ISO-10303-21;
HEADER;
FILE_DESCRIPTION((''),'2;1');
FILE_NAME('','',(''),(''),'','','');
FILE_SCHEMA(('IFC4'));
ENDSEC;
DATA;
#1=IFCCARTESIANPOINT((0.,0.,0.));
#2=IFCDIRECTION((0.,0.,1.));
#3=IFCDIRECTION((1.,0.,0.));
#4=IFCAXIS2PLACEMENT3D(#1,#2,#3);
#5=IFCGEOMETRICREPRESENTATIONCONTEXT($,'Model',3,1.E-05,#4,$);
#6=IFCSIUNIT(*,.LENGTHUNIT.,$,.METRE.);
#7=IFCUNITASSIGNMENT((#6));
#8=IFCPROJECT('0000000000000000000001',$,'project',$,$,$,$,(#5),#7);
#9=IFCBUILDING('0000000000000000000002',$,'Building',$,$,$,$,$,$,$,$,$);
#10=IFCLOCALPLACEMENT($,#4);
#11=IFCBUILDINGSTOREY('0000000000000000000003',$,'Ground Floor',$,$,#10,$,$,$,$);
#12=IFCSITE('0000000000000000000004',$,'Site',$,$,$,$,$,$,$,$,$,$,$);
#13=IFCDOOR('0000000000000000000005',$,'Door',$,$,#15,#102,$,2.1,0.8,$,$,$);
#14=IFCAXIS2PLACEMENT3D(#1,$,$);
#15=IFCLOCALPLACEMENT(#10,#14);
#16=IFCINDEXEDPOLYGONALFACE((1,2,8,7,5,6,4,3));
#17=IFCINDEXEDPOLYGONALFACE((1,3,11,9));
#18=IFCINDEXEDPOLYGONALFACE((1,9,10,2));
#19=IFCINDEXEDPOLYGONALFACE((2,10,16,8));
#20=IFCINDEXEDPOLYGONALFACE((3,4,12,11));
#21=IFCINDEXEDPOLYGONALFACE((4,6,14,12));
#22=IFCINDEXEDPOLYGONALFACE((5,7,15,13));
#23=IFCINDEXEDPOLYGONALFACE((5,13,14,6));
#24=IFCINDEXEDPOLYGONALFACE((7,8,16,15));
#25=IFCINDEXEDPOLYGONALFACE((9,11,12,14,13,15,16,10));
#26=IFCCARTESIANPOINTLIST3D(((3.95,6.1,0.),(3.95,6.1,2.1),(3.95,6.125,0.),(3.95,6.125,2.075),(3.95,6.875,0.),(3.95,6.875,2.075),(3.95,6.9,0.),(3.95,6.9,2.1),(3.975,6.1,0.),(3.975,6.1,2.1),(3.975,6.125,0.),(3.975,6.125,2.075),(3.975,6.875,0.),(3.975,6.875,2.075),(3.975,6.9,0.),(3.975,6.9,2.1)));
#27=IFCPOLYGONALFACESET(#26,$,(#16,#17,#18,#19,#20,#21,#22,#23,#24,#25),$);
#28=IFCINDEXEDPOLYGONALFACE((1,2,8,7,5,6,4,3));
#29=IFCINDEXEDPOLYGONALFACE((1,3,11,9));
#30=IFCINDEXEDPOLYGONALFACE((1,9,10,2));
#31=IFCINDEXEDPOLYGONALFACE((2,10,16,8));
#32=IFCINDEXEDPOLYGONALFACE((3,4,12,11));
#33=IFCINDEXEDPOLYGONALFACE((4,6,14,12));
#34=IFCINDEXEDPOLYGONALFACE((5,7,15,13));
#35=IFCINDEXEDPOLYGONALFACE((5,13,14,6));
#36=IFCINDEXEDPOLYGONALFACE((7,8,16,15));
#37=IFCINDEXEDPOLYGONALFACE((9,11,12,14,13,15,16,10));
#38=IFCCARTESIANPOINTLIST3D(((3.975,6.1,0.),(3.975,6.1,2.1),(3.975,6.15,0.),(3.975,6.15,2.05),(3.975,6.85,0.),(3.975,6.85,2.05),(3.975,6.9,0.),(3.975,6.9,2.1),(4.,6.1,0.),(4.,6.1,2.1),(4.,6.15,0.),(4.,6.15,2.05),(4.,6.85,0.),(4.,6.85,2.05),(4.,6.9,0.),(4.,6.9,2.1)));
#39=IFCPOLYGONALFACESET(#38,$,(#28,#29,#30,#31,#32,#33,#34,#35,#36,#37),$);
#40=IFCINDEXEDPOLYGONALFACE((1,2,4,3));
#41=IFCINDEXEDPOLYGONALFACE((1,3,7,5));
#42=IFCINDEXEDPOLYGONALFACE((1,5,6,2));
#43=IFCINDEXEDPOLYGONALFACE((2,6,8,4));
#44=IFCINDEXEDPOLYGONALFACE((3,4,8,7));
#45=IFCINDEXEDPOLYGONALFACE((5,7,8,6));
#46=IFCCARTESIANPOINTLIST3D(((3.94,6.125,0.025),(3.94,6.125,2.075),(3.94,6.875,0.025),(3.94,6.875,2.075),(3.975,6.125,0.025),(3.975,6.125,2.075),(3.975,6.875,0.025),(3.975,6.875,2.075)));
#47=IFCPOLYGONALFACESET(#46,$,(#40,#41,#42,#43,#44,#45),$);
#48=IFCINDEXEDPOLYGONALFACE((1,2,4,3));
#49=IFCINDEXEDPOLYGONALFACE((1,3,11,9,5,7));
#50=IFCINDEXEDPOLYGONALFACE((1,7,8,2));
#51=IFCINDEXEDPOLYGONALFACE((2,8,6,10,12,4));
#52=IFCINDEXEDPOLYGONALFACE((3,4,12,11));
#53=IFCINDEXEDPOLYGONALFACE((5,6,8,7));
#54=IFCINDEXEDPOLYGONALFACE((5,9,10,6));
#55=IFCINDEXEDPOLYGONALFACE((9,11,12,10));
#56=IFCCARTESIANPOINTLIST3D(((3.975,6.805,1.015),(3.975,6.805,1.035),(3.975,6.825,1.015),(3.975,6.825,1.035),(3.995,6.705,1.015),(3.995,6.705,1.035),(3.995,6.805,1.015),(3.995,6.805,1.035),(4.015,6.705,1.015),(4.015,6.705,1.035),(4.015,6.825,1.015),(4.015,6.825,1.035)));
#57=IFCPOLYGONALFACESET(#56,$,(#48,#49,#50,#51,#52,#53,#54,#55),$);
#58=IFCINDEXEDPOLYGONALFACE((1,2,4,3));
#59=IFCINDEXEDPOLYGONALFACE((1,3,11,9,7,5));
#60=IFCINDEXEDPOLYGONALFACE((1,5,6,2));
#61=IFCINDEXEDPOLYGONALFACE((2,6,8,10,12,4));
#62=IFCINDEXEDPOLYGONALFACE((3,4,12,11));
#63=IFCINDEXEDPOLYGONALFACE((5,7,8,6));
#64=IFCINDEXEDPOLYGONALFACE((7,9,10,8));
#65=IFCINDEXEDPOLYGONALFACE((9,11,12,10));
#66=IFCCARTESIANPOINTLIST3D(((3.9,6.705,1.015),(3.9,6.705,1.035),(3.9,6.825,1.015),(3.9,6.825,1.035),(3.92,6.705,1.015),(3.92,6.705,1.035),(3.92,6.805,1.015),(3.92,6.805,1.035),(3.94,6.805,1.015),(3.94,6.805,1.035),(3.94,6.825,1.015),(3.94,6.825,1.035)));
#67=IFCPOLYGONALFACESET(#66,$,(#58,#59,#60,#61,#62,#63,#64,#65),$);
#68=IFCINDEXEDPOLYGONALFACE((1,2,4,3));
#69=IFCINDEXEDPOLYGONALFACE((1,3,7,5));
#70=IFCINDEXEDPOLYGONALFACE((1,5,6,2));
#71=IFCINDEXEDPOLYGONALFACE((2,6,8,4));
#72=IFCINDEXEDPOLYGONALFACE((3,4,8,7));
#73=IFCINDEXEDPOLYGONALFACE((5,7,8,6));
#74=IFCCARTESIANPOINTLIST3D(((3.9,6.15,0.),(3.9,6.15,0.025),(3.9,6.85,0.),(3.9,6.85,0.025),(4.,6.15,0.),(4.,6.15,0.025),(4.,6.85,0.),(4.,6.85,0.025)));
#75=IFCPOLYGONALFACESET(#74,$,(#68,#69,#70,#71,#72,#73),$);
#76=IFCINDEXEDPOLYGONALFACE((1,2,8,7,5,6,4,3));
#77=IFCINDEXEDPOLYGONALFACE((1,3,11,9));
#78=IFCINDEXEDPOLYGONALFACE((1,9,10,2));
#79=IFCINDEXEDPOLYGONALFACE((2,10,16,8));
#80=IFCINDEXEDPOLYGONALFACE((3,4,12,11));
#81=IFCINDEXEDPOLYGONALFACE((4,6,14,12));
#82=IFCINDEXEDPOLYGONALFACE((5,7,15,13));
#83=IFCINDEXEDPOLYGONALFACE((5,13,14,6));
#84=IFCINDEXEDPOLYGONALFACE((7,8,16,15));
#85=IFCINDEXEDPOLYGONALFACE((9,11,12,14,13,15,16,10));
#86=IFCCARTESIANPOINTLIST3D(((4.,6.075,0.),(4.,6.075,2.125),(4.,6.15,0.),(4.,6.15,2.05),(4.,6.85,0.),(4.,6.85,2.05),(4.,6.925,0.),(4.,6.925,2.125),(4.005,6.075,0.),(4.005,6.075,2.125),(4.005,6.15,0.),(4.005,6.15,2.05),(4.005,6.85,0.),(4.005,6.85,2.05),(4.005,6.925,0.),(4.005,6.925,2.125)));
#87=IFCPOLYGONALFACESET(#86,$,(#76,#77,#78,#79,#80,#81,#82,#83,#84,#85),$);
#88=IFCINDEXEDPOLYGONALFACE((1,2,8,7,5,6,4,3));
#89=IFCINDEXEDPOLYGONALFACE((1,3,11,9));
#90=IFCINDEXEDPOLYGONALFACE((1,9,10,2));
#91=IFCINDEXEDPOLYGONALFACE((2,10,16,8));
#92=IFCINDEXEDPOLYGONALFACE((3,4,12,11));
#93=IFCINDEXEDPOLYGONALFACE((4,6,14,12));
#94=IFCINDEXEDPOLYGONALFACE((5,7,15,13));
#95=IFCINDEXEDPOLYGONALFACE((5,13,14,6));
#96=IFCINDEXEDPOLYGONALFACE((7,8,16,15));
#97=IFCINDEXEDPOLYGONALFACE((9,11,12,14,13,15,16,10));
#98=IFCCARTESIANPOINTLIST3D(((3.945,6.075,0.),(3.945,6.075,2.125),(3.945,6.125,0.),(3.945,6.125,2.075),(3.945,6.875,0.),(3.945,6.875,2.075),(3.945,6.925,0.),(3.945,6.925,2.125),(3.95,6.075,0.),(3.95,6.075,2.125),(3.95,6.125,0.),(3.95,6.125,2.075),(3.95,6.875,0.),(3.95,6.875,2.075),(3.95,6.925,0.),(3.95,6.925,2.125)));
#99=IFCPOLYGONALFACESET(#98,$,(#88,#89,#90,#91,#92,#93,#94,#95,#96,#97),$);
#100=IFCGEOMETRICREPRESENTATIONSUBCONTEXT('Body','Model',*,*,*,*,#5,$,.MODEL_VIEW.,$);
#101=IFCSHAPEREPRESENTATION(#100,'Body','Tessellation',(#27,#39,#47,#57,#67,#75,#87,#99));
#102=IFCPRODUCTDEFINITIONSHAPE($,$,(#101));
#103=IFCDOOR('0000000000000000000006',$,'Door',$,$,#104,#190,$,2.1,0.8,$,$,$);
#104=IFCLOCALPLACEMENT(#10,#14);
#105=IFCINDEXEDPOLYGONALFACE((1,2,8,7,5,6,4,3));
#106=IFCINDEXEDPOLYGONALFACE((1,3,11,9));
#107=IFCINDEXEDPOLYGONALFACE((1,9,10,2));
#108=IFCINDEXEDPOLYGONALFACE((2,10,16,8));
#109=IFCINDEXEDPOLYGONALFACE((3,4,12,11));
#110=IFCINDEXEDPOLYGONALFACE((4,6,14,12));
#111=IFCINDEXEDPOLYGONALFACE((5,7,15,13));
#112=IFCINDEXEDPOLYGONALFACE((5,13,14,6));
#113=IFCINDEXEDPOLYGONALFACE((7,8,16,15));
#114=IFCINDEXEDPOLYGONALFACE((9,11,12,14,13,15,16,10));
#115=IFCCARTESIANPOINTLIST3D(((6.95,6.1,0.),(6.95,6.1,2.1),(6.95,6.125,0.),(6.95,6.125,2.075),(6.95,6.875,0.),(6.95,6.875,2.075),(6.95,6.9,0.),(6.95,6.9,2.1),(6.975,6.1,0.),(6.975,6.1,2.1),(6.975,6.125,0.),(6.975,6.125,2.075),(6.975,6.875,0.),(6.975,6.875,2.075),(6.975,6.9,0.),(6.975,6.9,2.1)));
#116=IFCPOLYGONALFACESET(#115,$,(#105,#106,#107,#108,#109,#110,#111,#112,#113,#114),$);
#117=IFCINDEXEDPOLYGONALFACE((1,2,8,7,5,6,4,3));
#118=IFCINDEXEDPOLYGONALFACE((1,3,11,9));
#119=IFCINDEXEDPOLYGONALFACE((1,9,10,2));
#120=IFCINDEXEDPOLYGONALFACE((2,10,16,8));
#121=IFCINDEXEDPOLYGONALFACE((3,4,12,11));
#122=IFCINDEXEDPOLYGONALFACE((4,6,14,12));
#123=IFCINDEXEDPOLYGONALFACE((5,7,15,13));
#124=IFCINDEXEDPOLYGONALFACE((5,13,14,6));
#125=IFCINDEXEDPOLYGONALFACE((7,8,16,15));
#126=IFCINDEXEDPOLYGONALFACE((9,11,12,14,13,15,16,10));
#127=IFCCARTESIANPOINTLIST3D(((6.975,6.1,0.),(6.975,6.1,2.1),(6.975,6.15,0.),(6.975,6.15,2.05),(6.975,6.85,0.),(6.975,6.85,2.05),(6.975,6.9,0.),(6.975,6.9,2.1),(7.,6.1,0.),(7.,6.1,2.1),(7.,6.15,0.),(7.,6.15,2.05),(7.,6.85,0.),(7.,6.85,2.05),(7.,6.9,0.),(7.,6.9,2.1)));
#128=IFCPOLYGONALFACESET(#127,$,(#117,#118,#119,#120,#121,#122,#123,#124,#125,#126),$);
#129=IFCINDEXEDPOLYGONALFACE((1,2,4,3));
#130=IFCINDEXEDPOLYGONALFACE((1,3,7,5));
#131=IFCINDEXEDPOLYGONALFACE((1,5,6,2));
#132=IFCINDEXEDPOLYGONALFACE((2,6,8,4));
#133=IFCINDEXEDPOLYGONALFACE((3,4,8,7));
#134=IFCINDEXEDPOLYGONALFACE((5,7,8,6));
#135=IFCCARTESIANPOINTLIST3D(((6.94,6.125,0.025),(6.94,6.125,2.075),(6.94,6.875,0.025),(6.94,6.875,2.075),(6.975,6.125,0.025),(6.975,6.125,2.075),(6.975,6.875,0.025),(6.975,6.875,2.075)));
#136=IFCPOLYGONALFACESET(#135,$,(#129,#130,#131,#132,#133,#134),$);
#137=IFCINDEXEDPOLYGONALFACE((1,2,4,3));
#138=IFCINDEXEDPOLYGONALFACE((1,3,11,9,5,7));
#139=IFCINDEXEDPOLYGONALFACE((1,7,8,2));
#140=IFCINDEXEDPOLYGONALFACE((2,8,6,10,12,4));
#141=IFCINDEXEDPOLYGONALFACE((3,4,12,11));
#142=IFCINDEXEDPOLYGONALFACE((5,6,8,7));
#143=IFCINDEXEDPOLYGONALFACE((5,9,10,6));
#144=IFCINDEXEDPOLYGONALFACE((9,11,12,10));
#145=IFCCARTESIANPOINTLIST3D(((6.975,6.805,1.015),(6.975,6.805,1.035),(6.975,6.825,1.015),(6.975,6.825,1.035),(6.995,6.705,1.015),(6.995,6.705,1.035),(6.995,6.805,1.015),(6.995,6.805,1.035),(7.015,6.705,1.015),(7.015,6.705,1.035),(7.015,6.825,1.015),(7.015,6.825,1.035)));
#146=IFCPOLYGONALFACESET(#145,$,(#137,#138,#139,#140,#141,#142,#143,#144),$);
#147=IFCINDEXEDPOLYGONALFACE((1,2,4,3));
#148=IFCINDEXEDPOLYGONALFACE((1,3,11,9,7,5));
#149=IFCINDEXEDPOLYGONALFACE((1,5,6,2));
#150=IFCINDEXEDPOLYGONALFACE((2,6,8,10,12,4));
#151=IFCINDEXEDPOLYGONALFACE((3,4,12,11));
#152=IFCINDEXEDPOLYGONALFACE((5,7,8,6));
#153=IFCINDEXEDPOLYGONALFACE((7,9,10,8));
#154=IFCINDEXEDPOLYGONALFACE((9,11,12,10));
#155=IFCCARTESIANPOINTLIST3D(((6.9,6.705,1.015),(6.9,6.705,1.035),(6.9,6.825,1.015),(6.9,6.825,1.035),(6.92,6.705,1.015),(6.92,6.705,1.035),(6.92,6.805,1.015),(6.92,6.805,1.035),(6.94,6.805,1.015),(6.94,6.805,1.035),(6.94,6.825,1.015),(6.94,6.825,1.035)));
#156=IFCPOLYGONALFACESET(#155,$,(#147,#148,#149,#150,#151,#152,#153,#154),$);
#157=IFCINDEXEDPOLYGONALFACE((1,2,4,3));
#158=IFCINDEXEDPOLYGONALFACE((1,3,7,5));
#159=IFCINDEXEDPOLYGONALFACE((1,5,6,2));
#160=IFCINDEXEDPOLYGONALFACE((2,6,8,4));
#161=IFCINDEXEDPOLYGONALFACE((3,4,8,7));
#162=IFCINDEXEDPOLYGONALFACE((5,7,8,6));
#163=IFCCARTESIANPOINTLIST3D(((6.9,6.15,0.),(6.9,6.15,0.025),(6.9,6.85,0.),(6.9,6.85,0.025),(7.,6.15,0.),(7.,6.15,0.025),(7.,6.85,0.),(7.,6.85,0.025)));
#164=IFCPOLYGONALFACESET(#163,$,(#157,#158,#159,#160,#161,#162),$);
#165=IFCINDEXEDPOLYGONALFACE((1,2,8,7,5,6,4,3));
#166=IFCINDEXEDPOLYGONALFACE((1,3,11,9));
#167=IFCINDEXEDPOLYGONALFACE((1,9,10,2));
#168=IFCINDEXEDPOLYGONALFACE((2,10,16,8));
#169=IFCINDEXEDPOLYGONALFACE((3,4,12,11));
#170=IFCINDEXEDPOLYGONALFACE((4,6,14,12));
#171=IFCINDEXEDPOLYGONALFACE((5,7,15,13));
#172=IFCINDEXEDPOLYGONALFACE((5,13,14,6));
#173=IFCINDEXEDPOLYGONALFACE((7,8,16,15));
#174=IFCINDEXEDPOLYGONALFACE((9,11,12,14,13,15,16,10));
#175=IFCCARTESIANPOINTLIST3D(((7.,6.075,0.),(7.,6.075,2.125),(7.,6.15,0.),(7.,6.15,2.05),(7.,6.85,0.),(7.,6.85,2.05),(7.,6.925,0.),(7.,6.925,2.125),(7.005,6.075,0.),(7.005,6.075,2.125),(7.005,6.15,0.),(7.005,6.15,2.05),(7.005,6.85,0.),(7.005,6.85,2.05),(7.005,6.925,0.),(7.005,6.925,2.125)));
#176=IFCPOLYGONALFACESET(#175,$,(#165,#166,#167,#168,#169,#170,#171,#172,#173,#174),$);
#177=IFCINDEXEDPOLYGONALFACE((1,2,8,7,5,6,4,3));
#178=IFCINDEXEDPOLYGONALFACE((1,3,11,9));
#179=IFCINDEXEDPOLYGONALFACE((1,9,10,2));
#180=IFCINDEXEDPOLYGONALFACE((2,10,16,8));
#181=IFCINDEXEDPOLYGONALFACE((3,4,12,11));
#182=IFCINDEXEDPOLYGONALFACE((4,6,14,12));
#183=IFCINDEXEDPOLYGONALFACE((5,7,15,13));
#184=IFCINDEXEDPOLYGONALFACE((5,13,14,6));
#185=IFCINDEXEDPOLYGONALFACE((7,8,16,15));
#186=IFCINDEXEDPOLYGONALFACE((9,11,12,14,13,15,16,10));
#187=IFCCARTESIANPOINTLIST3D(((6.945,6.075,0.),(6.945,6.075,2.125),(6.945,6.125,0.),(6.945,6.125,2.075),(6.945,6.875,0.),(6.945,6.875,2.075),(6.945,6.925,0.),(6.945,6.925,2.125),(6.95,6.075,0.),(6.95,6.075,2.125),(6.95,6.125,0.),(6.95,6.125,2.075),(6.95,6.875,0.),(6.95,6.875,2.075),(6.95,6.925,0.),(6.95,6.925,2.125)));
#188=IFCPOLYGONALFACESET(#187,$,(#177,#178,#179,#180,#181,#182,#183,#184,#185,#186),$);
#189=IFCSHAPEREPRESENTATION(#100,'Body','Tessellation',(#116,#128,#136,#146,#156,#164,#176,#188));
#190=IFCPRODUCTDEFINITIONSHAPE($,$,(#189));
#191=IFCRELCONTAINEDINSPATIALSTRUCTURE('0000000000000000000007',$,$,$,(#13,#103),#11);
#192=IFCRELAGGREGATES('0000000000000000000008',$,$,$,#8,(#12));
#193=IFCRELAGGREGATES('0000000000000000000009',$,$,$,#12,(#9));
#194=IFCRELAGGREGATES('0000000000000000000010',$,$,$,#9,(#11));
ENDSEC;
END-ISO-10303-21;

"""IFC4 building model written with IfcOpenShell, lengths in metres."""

from ifc_helpers import new_model, si_unit, frame, origin_with_axes, place, context, subcontext, project, spatial, line, indexed_curve, outline, extrude, element, save


model = new_model("IFC4")

# Units and contexts
model_context = context("Model", 3, precision=1e-05, world=origin_with_axes())
body_context = subcontext(model_context, "Body", "Model", "MODEL_VIEW")
ifc_project = project(units=[si_unit("LENGTHUNIT", "METRE")], contexts=[model_context])

# Site, building, storey
site = spatial("IfcSite", under=ifc_project, Name="Site")
building = spatial("IfcBuilding", under=site, Name="Building")
storey_placement = place(None, origin_with_axes())
storey = spatial("IfcBuildingStorey", under=building, at=storey_placement, Name="Ground Floor")

# Doors
door_1_placement = place(storey_placement, frame((4.0, 6.1, 0.0), z_axis=(0.0, 0.0, 1.0), x_axis=(0.0, 1.0, 0.0)))
element("IfcDoor", 1, at=door_1_placement, inside=storey, Name="Door", OverallHeight=2.1, OverallWidth=0.8, context=body_context, shape_type="SweptSolid", body=[
    extrude(outline(indexed_curve([(0.0, 0.0), (0.0, 2.1), (0.8, 2.1), (0.8, 0.0), (0.775, 0.0), (0.775, 2.075), (0.025, 2.075), (0.025, 0.0)], segments=[line(1, 2, 3, 4, 5, 6, 7, 8, 1)])), frame((0.0, 0.025, 0.0), z_axis=(0.0, -1.0, 0.0), x_axis=(1.0, 0.0, 0.0)), (0.0, 0.0, -1.0), 0.025),
    extrude(outline(indexed_curve([(0.0, 0.0), (0.0, 2.1), (0.8, 2.1), (0.8, 0.0), (0.75, 0.0), (0.75, 2.05), (0.05, 2.05), (0.05, 0.0)], segments=[line(1, 2, 3, 4, 5, 6, 7, 8, 1)])), frame((0.0, 0.0, 0.0), z_axis=(0.0, -1.0, 0.0), x_axis=(1.0, 0.0, 0.0)), (0.0, 0.0, -1.0), 0.025),
    extrude(outline(indexed_curve([(0.0, 0.0), (0.75, 0.0), (0.75, 0.035), (0.0, 0.035)], segments=[line(1, 2, 3, 4, 1)])), frame((0.025, 0.025, 0.025), z_axis=(0.0, 0.0, 1.0), x_axis=(1.0, 0.0, 0.0)), (0.0, 0.0, 1.0), 2.05),
    extrude(outline(indexed_curve([(0.0, 0.0), (0.0, -0.04), (-0.12, -0.04), (-0.12, -0.02), (-0.02, -0.02), (-0.02, 0.0)], segments=[line(1, 2, 3, 4, 5, 6, 1)])), frame((0.725, 0.025, 1.015), z_axis=(0.0, 0.0, 1.0), x_axis=(1.0, 0.0, 0.0)), (0.0, 0.0, 1.0), 0.02),
    extrude(outline(indexed_curve([(0.0, 0.0), (0.0, 0.04), (-0.12, 0.04), (-0.12, 0.02), (-0.02, 0.02), (-0.02, 0.0)], segments=[line(1, 2, 3, 4, 5, 6, 1)])), frame((0.725, 0.06, 1.015), z_axis=(0.0, 0.0, 1.0), x_axis=(1.0, 0.0, 0.0)), (0.0, 0.0, 1.0), 0.02),
    extrude(outline(indexed_curve([(0.0, 0.0), (0.7, 0.0), (0.7, 0.1), (0.0, 0.1)], segments=[line(1, 2, 3, 4, 1)])), frame((0.05, 0.0, 0.0), z_axis=(0.0, 0.0, 1.0), x_axis=(1.0, 0.0, 0.0)), (0.0, 0.0, 1.0), 0.025),
    extrude(outline(indexed_curve([(0.0, 0.0), (0.0, 2.125), (0.85, 2.125), (0.85, 0.0), (0.775, 0.0), (0.775, 2.05), (0.075, 2.05), (0.075, 0.0)], segments=[line(1, 2, 3, 4, 5, 6, 7, 8, 1)])), frame((-0.025, -0.005, 0.0), z_axis=(0.0, -1.0, 0.0), x_axis=(1.0, 0.0, 0.0)), (0.0, 0.0, -1.0), 0.005),
    extrude(outline(indexed_curve([(0.0, 0.0), (0.0, 2.125), (0.85, 2.125), (0.85, 0.0), (0.8, 0.0), (0.8, 2.075), (0.05, 2.075), (0.05, 0.0)], segments=[line(1, 2, 3, 4, 5, 6, 7, 8, 1)])), frame((-0.025, 0.05, 0.0), z_axis=(0.0, -1.0, 0.0), x_axis=(1.0, 0.0, 0.0)), (0.0, 0.0, -1.0), 0.005),
])
door_2_placement = place(storey_placement, frame((7.0, 6.1, 0.0), z_axis=(0.0, 0.0, 1.0), x_axis=(0.0, 1.0, 0.0)))
element("IfcDoor", 2, at=door_2_placement, inside=storey, Name="Door", OverallHeight=2.1, OverallWidth=0.8, context=body_context, shape_type="SweptSolid", body=[
    extrude(outline(indexed_curve([(0.0, 0.0), (0.0, 2.1), (0.8, 2.1), (0.8, 0.0), (0.775, 0.0), (0.775, 2.075), (0.025, 2.075), (0.025, 0.0)], segments=[line(1, 2, 3, 4, 5, 6, 7, 8, 1)])), frame((0.0, 0.025, 0.0), z_axis=(0.0, -1.0, 0.0), x_axis=(1.0, 0.0, 0.0)), (0.0, 0.0, -1.0), 0.025),
    extrude(outline(indexed_curve([(0.0, 0.0), (0.0, 2.1), (0.8, 2.1), (0.8, 0.0), (0.75, 0.0), (0.75, 2.05), (0.05, 2.05), (0.05, 0.0)], segments=[line(1, 2, 3, 4, 5, 6, 7, 8, 1)])), frame((0.0, 0.0, 0.0), z_axis=(0.0, -1.0, 0.0), x_axis=(1.0, 0.0, 0.0)), (0.0, 0.0, -1.0), 0.025),
    extrude(outline(indexed_curve([(0.0, 0.0), (0.75, 0.0), (0.75, 0.035), (0.0, 0.035)], segments=[line(1, 2, 3, 4, 1)])), frame((0.025, 0.025, 0.025), z_axis=(0.0, 0.0, 1.0), x_axis=(1.0, 0.0, 0.0)), (0.0, 0.0, 1.0), 2.05),
    extrude(outline(indexed_curve([(0.0, 0.0), (0.0, -0.04), (-0.12, -0.04), (-0.12, -0.02), (-0.02, -0.02), (-0.02, 0.0)], segments=[line(1, 2, 3, 4, 5, 6, 1)])), frame((0.725, 0.025, 1.015), z_axis=(0.0, 0.0, 1.0), x_axis=(1.0, 0.0, 0.0)), (0.0, 0.0, 1.0), 0.02),
    extrude(outline(indexed_curve([(0.0, 0.0), (0.0, 0.04), (-0.12, 0.04), (-0.12, 0.02), (-0.02, 0.02), (-0.02, 0.0)], segments=[line(1, 2, 3, 4, 5, 6, 1)])), frame((0.725, 0.06, 1.015), z_axis=(0.0, 0.0, 1.0), x_axis=(1.0, 0.0, 0.0)), (0.0, 0.0, 1.0), 0.02),
    extrude(outline(indexed_curve([(0.0, 0.0), (0.7, 0.0), (0.7, 0.1), (0.0, 0.1)], segments=[line(1, 2, 3, 4, 1)])), frame((0.05, 0.0, 0.0), z_axis=(0.0, 0.0, 1.0), x_axis=(1.0, 0.0, 0.0)), (0.0, 0.0, 1.0), 0.025),
    extrude(outline(indexed_curve([(0.0, 0.0), (0.0, 2.125), (0.85, 2.125), (0.85, 0.0), (0.775, 0.0), (0.775, 2.05), (0.075, 2.05), (0.075, 0.0)], segments=[line(1, 2, 3, 4, 5, 6, 7, 8, 1)])), frame((-0.025, -0.005, 0.0), z_axis=(0.0, -1.0, 0.0), x_axis=(1.0, 0.0, 0.0)), (0.0, 0.0, -1.0), 0.005),
    extrude(outline(indexed_curve([(0.0, 0.0), (0.0, 2.125), (0.85, 2.125), (0.85, 0.0), (0.8, 0.0), (0.8, 2.075), (0.05, 2.075), (0.05, 0.0)], segments=[line(1, 2, 3, 4, 5, 6, 7, 8, 1)])), frame((-0.025, 0.05, 0.0), z_axis=(0.0, -1.0, 0.0), x_axis=(1.0, 0.0, 0.0)), (0.0, 0.0, -1.0), 0.005),
])

save(model, "model.ifc")
